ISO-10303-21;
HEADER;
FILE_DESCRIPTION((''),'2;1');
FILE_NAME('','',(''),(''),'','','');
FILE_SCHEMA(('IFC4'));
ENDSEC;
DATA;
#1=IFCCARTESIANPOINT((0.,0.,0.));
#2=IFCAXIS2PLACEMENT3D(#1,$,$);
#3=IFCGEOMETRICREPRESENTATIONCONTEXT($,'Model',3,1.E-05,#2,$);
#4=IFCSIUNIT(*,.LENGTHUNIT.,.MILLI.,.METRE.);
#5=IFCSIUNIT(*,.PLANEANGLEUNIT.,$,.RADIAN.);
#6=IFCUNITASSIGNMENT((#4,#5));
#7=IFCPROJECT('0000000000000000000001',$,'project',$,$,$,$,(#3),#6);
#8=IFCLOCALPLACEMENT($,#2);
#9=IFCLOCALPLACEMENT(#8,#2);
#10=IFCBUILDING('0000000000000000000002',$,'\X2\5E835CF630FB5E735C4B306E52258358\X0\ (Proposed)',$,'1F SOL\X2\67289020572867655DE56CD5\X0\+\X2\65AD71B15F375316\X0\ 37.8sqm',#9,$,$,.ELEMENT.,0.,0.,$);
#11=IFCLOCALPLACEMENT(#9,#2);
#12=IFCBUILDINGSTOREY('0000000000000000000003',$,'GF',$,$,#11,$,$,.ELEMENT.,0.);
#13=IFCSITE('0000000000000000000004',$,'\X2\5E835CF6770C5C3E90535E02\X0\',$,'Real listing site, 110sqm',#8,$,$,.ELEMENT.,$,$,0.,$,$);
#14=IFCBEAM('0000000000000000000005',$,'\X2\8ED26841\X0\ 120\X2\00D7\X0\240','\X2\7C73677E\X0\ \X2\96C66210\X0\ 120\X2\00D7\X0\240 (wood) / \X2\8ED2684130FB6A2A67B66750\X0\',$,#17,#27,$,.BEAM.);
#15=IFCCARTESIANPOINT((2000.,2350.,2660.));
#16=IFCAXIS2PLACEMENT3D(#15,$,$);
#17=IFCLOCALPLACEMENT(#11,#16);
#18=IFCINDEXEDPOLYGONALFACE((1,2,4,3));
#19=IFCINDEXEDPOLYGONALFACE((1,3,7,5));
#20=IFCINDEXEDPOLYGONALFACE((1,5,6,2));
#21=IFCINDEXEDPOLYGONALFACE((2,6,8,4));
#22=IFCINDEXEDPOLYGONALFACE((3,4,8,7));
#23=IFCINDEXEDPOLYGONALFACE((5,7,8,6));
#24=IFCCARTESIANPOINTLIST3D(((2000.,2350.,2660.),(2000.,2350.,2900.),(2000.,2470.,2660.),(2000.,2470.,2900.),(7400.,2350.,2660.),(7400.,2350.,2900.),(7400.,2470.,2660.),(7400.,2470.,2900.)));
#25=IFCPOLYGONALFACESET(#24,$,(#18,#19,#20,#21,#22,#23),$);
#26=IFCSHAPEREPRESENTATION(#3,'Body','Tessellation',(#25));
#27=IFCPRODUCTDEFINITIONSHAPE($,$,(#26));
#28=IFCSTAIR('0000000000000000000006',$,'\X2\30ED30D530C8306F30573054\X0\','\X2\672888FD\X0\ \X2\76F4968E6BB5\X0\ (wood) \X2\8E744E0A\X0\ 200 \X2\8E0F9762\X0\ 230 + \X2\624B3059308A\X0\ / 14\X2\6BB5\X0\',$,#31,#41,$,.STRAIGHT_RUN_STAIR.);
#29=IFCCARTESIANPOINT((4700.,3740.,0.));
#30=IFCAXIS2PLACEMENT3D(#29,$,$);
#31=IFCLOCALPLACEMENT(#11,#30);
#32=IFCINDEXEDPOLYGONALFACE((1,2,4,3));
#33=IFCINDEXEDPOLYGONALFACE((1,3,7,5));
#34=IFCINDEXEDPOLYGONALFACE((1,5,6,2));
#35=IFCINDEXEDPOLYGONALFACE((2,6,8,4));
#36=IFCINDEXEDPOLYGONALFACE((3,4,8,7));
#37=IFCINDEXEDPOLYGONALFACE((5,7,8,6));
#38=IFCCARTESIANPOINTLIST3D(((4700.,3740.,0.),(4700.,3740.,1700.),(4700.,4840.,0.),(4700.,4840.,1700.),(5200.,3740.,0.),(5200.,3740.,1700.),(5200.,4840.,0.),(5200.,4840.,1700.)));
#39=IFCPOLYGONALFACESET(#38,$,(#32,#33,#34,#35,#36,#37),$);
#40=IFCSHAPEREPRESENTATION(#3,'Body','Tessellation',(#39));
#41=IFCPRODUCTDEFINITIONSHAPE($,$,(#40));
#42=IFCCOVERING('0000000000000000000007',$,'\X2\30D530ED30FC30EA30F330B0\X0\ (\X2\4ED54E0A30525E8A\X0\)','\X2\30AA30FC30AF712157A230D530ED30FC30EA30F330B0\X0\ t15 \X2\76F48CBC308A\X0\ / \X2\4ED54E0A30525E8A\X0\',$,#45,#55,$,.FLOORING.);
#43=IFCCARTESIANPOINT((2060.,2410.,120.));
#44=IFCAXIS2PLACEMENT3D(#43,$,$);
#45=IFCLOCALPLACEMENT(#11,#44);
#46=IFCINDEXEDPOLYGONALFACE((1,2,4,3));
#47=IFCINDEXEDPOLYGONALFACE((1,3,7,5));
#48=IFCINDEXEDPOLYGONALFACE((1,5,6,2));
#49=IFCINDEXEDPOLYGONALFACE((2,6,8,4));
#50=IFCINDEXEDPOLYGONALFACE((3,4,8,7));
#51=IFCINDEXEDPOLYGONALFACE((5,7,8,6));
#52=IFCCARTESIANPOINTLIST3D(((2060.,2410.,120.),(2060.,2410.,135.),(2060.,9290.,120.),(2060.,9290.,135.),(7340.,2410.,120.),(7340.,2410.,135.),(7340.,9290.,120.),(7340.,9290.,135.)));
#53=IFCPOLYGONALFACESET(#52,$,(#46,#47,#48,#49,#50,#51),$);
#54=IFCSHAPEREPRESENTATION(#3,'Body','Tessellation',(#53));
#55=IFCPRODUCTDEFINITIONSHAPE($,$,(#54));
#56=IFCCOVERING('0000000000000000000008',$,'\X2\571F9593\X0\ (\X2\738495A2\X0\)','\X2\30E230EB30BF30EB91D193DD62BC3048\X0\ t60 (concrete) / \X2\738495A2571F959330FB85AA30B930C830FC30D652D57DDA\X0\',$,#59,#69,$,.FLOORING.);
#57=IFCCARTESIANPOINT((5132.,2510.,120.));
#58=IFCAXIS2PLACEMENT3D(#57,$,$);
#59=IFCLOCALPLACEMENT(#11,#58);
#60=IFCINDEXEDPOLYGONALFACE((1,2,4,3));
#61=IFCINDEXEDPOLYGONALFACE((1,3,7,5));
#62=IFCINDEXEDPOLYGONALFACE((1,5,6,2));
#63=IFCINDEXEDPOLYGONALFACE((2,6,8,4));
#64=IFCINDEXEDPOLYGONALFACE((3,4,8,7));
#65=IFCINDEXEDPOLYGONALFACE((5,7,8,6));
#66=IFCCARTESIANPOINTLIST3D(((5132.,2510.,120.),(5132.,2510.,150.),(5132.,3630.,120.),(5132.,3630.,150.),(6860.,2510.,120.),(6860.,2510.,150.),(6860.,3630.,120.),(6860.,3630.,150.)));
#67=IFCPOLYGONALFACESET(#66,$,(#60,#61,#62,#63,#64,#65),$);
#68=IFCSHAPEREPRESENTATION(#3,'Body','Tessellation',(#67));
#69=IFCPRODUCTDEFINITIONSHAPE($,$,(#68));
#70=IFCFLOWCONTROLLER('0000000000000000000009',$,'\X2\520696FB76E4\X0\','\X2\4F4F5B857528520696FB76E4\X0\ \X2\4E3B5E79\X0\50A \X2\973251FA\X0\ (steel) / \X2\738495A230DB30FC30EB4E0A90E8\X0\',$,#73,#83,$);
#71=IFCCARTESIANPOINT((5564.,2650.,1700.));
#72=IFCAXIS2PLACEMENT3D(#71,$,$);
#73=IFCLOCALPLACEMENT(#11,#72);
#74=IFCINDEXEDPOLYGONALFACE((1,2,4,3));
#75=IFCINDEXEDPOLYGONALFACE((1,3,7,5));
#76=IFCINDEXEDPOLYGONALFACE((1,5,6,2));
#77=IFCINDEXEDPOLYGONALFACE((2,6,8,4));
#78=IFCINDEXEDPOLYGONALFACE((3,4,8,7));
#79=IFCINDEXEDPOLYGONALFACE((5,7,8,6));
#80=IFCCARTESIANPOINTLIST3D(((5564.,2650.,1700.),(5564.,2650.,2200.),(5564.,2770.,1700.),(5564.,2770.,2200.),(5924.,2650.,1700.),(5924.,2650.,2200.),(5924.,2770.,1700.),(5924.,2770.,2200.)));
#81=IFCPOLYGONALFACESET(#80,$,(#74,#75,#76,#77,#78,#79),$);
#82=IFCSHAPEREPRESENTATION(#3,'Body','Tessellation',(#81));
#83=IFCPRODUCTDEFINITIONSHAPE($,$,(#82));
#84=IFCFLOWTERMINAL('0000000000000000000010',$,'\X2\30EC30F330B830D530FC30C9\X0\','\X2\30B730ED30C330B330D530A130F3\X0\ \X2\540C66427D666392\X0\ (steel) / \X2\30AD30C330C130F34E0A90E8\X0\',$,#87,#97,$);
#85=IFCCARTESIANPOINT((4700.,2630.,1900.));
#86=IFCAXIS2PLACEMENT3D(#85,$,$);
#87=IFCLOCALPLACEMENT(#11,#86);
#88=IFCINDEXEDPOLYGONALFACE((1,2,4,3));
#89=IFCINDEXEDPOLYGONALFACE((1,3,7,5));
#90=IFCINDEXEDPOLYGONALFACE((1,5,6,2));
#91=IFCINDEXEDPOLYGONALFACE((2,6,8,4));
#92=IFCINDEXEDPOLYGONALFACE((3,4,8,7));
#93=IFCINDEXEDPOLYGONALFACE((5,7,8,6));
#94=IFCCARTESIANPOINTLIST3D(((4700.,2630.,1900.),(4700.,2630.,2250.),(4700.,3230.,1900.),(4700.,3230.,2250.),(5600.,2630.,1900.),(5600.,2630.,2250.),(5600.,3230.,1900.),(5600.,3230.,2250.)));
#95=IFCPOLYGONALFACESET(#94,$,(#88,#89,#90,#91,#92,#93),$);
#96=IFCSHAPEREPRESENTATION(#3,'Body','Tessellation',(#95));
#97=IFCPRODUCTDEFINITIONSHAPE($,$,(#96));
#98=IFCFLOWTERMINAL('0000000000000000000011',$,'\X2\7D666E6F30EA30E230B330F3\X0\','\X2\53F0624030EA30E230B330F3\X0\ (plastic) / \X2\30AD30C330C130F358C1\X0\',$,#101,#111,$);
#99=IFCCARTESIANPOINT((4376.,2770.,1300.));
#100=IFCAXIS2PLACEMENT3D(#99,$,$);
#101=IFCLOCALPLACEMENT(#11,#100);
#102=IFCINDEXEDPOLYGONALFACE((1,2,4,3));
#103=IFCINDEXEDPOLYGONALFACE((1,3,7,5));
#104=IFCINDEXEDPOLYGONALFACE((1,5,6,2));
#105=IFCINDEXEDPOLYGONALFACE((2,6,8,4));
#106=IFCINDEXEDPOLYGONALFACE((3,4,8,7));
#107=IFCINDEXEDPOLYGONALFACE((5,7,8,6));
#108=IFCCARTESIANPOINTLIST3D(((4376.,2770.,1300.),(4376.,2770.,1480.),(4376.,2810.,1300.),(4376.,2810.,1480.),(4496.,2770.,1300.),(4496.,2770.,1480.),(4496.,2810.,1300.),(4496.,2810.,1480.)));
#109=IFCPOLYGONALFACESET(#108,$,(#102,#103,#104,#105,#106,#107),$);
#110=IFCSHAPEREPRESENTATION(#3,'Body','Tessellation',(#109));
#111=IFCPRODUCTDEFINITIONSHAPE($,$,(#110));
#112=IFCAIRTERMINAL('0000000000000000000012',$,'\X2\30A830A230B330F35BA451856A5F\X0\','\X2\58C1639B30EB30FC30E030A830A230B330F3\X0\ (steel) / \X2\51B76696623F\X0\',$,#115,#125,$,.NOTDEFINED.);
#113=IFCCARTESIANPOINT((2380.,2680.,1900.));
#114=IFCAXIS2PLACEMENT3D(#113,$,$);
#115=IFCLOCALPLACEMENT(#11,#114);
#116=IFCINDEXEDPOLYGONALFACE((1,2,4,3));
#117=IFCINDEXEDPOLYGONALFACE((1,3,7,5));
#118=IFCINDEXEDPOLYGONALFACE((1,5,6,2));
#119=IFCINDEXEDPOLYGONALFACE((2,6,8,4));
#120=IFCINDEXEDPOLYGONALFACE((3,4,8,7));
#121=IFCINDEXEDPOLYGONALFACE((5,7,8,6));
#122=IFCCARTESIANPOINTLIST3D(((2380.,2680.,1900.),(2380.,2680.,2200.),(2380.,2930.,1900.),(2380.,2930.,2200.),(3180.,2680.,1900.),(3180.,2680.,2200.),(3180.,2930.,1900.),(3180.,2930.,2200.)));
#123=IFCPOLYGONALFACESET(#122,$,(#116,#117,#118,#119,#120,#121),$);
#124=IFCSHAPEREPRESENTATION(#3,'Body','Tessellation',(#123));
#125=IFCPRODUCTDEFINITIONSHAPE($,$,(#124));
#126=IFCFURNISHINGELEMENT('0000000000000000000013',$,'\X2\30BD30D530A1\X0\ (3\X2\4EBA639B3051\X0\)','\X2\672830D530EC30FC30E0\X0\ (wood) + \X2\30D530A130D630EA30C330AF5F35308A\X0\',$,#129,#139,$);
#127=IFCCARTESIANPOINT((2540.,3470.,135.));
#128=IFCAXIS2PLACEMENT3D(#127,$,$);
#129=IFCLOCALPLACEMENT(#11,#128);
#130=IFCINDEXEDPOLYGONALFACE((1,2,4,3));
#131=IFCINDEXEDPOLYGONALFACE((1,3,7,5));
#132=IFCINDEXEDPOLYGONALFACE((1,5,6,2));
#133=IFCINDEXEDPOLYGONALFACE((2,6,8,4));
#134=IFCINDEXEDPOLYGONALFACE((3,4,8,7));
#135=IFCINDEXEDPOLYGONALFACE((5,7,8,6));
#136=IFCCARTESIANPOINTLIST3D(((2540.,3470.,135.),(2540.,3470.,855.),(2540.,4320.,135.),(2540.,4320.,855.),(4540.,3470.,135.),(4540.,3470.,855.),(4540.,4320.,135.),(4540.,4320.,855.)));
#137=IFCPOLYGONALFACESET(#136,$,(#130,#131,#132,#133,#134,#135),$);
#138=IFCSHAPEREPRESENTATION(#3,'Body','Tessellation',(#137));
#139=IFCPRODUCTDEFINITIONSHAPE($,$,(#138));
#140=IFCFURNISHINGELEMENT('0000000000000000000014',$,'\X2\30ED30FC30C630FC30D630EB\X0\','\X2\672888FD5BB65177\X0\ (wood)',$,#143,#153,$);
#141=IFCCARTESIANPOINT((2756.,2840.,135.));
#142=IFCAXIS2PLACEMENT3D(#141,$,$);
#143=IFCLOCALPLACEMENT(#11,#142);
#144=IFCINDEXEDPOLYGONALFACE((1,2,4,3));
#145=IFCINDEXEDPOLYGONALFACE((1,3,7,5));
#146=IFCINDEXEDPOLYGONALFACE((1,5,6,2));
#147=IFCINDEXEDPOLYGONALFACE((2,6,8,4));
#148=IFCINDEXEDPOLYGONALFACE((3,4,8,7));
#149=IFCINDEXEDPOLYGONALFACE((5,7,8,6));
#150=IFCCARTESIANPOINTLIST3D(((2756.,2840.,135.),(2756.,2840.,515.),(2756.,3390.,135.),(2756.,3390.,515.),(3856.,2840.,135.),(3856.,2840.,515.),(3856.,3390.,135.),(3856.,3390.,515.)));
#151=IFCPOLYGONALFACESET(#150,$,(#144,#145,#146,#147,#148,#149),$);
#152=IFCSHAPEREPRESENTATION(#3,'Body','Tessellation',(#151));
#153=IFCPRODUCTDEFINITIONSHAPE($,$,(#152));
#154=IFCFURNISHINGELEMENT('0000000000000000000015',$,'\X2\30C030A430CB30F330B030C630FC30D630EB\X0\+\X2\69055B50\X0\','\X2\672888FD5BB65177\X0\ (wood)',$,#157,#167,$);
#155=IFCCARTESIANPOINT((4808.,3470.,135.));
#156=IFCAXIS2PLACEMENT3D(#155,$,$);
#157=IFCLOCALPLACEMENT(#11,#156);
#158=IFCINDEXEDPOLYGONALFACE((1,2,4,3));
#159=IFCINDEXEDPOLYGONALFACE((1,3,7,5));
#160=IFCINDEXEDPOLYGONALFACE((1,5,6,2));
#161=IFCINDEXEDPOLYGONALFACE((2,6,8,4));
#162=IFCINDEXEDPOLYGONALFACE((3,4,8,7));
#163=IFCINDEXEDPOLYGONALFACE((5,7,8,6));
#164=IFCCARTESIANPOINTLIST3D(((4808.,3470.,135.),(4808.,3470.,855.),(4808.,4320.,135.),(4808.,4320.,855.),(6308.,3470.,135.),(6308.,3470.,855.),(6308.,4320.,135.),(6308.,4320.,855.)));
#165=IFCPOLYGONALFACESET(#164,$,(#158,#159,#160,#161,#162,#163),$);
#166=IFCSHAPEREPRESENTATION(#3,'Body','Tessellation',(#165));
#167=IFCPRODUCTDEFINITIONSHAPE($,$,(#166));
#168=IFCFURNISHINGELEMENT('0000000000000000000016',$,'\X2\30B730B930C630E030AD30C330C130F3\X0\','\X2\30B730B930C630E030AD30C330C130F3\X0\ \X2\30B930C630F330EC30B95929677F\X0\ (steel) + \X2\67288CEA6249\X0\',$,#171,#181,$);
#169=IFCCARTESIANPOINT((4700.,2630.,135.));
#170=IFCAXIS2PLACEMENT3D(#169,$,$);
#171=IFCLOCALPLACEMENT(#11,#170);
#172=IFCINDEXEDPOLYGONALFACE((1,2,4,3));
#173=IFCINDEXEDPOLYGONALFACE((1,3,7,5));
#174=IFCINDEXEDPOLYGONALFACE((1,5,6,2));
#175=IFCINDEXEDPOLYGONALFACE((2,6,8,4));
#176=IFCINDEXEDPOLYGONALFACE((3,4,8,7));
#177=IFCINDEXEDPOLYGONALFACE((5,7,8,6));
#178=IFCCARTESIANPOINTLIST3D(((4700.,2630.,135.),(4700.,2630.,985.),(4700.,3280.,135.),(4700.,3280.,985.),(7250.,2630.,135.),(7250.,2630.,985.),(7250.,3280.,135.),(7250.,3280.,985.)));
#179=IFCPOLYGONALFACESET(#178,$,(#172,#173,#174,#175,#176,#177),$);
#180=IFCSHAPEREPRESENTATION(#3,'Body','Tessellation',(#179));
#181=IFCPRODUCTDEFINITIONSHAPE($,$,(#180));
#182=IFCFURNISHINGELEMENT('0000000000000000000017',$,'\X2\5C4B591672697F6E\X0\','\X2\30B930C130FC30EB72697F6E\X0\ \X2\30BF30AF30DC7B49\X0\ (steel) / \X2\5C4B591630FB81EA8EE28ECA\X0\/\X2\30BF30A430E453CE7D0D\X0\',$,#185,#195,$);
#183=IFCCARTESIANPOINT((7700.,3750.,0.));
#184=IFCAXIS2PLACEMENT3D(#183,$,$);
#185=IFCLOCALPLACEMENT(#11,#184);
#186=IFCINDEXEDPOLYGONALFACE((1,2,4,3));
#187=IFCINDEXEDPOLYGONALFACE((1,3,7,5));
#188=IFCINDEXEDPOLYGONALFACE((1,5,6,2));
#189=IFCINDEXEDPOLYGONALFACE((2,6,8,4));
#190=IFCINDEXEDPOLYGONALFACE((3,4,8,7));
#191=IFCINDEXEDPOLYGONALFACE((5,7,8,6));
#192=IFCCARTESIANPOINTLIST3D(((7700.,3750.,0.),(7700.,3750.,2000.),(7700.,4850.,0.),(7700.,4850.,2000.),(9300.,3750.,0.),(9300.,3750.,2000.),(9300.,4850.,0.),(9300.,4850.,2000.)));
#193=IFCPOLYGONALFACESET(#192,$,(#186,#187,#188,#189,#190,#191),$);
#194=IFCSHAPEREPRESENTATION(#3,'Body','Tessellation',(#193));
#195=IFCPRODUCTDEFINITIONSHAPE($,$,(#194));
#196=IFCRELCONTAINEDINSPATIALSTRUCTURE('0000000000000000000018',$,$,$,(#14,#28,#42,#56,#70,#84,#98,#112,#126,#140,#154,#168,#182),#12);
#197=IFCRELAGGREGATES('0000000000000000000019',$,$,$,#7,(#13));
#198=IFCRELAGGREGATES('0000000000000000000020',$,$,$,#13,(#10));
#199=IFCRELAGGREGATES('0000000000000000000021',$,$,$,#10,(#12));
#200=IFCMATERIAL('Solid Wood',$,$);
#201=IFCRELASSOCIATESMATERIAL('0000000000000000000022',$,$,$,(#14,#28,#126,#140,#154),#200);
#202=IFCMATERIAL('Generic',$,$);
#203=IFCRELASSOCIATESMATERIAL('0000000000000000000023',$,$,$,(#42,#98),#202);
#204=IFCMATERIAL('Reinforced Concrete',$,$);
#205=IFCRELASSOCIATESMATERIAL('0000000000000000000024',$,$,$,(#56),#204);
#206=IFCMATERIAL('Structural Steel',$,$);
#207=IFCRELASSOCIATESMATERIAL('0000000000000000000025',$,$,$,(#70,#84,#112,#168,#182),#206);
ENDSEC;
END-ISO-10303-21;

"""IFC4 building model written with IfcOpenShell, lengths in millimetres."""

from ifc_helpers import new_model, si_unit, frame, frame_2d, origin, place, context, project, spatial, rectangle, extrude, material, element, save


model = new_model("IFC4")

# Units and contexts
model_context = context("Model", 3, precision=1e-05, world=origin())
ifc_project = project(units=[si_unit("LENGTHUNIT", "METRE", prefix="MILLI"), si_unit("PLANEANGLEUNIT", "RADIAN")], contexts=[model_context])

# Site, building, storey
site_placement = place(None, origin())
site = spatial("IfcSite", under=ifc_project, at=site_placement, Name="広島県尾道市", ObjectType="Real listing site, 110sqm", CompositionType="ELEMENT", RefElevation=0.0)
building_placement = place(site_placement, origin())
building = spatial("IfcBuilding", under=site, at=building_placement, Name="広島・平屋の別荘 (Proposed)", ObjectType="1F SOL木造在来工法+断熱強化 37.8sqm", CompositionType="ELEMENT", ElevationOfRefHeight=0.0, ElevationOfTerrain=0.0)
storey_placement = place(building_placement, origin())
storey = spatial("IfcBuildingStorey", under=building, at=storey_placement, Name="GF", CompositionType="ELEMENT", Elevation=0.0)

# Beam
ifc_material_1 = material(Name="Solid Wood")
beam_1_placement = place(storey_placement, frame((2000.0, 2350.0, 2660.0)))
element("IfcBeam", 1, at=beam_1_placement, inside=storey, material=ifc_material_1, Name="軒桁 120×240", Description="米松 集成 120×240 (wood) / 軒桁・横架材", PredefinedType="BEAM", context=model_context, shape_type="SweptSolid", body=[
    extrude(rectangle(XDim=5400.0, YDim=120.0, at=frame_2d((2700.0, 60.0))), frame((2000.0, 2350.0, 2660.0)), (0.0, 0.0, 1.0), 240.0),
])

# Stair
stair_placement = place(storey_placement, frame((4700.0, 3740.0, 0.0)))
element("IfcStair", 2, at=stair_placement, inside=storey, material=ifc_material_1, Name="ロフトはしご", Description="木製 直階段 (wood) 蹴上 200 踏面 230 + 手すり / 14段", PredefinedType="STRAIGHT_RUN_STAIR", context=model_context, shape_type="SweptSolid", body=[
    extrude(rectangle(XDim=500.0, YDim=1100.0, at=frame_2d((250.0, 550.0))), frame((4700.0, 3740.0, 0.0)), (0.0, 0.0, 1.0), 1700.0),
])

# Coverings
ifc_material_2 = material(Name="Generic")
covering_1_placement = place(storey_placement, frame((2060.0, 2410.0, 120.0)))
element("IfcCovering", 3, at=covering_1_placement, inside=storey, material=ifc_material_2, Name="フローリング (仕上げ床)", Description="オーク無垢フローリング t15 直貼り / 仕上げ床", PredefinedType="FLOORING", context=model_context, shape_type="SweptSolid", body=[
    extrude(rectangle(XDim=5280.0, YDim=6880.0, at=frame_2d((2640.0, 3440.0))), frame((2060.0, 2410.0, 120.0)), (0.0, 0.0, 1.0), 15.0),
])
ifc_material_3 = material(Name="Reinforced Concrete")
covering_2_placement = place(storey_placement, frame((5132.0, 2510.0, 120.0)))
element("IfcCovering", 4, at=covering_2_placement, inside=storey, material=ifc_material_3, Name="土間 (玄関)", Description="モルタル金鏝押え t60 (concrete) / 玄関土間・薪ストーブ動線", PredefinedType="FLOORING", context=model_context, shape_type="SweptSolid", body=[
    extrude(rectangle(XDim=1728.0, YDim=1120.0, at=frame_2d((864.0, 560.0))), frame((5132.0, 2510.0, 120.0)), (0.0, 0.0, 1.0), 30.0),
])

# Flow controller
ifc_material_4 = material(Name="Structural Steel")
flow_controller_placement = place(storey_placement, frame((5564.0, 2650.0, 1700.0)))
element("IfcFlowController", 5, at=flow_controller_placement, inside=storey, material=ifc_material_4, Name="分電盤", Description="住宅用分電盤 主幹50A 露出 (steel) / 玄関ホール上部", context=model_context, shape_type="SweptSolid", body=[
    extrude(rectangle(XDim=360.0, YDim=120.0, at=frame_2d((180.0, 60.0))), frame((5564.0, 2650.0, 1700.0)), (0.0, 0.0, 1.0), 500.0),
])

# Flow terminals
flow_terminal_1_placement = place(storey_placement, frame((4700.0, 2630.0, 1900.0)))
element("IfcFlowTerminal", 6, at=flow_terminal_1_placement, inside=storey, material=ifc_material_4, Name="レンジフード", Description="シロッコファン 同時給排 (steel) / キッチン上部", context=model_context, shape_type="SweptSolid", body=[
    extrude(rectangle(XDim=900.0, YDim=600.0, at=frame_2d((450.0, 300.0))), frame((4700.0, 2630.0, 1900.0)), (0.0, 0.0, 1.0), 350.0),
])
flow_terminal_2_placement = place(storey_placement, frame((4376.0, 2770.0, 1300.0)))
element("IfcFlowTerminal", 7, at=flow_terminal_2_placement, inside=storey, material=ifc_material_2, Name="給湯リモコン", Description="台所リモコン (plastic) / キッチン壁", context=model_context, shape_type="SweptSolid", body=[
    extrude(rectangle(XDim=120.0, YDim=40.0, at=frame_2d((60.0, 20.0))), frame((4376.0, 2770.0, 1300.0)), (0.0, 0.0, 1.0), 180.0),
])

# Air terminal
air_terminal_placement = place(storey_placement, frame((2380.0, 2680.0, 1900.0)))
element("IfcAirTerminal", 8, at=air_terminal_placement, inside=storey, material=ifc_material_4, Name="エアコン室内機", Description="壁掛ルームエアコン (steel) / 冷暖房", PredefinedType="NOTDEFINED", context=model_context, shape_type="SweptSolid", body=[
    extrude(rectangle(XDim=800.0, YDim=250.0, at=frame_2d((400.0, 125.0))), frame((2380.0, 2680.0, 1900.0)), (0.0, 0.0, 1.0), 300.0),
])

# Furnishing elements
furnishing_1_placement = place(storey_placement, frame((2540.0, 3470.0, 135.0)))
element("IfcFurnishingElement", 9, at=furnishing_1_placement, inside=storey, material=ifc_material_1, Name="ソファ (3人掛け)", Description="木フレーム (wood) + ファブリック張り", context=model_context, shape_type="SweptSolid", body=[
    extrude(rectangle(XDim=2000.0, YDim=850.0, at=frame_2d((1000.0, 425.0))), frame((2540.0, 3470.0, 135.0)), (0.0, 0.0, 1.0), 720.0),
])
furnishing_2_placement = place(storey_placement, frame((2756.0, 2840.0, 135.0)))
element("IfcFurnishingElement", 10, at=furnishing_2_placement, inside=storey, material=ifc_material_1, Name="ローテーブル", Description="木製家具 (wood)", context=model_context, shape_type="SweptSolid", body=[
    extrude(rectangle(XDim=1100.0, YDim=550.0, at=frame_2d((550.0, 275.0))), frame((2756.0, 2840.0, 135.0)), (0.0, 0.0, 1.0), 380.0),
])
furnishing_3_placement = place(storey_placement, frame((4808.0, 3470.0, 135.0)))
element("IfcFurnishingElement", 11, at=furnishing_3_placement, inside=storey, material=ifc_material_1, Name="ダイニングテーブル+椅子", Description="木製家具 (wood)", context=model_context, shape_type="SweptSolid", body=[
    extrude(rectangle(XDim=1500.0, YDim=850.0, at=frame_2d((750.0, 425.0))), frame((4808.0, 3470.0, 135.0)), (0.0, 0.0, 1.0), 720.0),
])
furnishing_4_placement = place(storey_placement, frame((4700.0, 2630.0, 135.0)))
element("IfcFurnishingElement", 12, at=furnishing_4_placement, inside=storey, material=ifc_material_4, Name="システムキッチン", Description="システムキッチン ステンレス天板 (steel) + 木質扉", context=model_context, shape_type="SweptSolid", body=[
    extrude(rectangle(XDim=2550.0, YDim=650.0, at=frame_2d((1275.0, 325.0))), frame((4700.0, 2630.0, 135.0)), (0.0, 0.0, 1.0), 850.0),
])
furnishing_5_placement = place(storey_placement, frame((7700.0, 3750.0, 0.0)))
element("IfcFurnishingElement", 13, at=furnishing_5_placement, inside=storey, material=ifc_material_4, Name="屋外物置", Description="スチール物置 タクボ等 (steel) / 屋外・自転車/タイヤ収納", context=model_context, shape_type="SweptSolid", body=[
    extrude(rectangle(XDim=1600.0, YDim=1100.0, at=frame_2d((800.0, 550.0))), frame((7700.0, 3750.0, 0.0)), (0.0, 0.0, 1.0), 2000.0),
])

save(model, "model.ifc")
